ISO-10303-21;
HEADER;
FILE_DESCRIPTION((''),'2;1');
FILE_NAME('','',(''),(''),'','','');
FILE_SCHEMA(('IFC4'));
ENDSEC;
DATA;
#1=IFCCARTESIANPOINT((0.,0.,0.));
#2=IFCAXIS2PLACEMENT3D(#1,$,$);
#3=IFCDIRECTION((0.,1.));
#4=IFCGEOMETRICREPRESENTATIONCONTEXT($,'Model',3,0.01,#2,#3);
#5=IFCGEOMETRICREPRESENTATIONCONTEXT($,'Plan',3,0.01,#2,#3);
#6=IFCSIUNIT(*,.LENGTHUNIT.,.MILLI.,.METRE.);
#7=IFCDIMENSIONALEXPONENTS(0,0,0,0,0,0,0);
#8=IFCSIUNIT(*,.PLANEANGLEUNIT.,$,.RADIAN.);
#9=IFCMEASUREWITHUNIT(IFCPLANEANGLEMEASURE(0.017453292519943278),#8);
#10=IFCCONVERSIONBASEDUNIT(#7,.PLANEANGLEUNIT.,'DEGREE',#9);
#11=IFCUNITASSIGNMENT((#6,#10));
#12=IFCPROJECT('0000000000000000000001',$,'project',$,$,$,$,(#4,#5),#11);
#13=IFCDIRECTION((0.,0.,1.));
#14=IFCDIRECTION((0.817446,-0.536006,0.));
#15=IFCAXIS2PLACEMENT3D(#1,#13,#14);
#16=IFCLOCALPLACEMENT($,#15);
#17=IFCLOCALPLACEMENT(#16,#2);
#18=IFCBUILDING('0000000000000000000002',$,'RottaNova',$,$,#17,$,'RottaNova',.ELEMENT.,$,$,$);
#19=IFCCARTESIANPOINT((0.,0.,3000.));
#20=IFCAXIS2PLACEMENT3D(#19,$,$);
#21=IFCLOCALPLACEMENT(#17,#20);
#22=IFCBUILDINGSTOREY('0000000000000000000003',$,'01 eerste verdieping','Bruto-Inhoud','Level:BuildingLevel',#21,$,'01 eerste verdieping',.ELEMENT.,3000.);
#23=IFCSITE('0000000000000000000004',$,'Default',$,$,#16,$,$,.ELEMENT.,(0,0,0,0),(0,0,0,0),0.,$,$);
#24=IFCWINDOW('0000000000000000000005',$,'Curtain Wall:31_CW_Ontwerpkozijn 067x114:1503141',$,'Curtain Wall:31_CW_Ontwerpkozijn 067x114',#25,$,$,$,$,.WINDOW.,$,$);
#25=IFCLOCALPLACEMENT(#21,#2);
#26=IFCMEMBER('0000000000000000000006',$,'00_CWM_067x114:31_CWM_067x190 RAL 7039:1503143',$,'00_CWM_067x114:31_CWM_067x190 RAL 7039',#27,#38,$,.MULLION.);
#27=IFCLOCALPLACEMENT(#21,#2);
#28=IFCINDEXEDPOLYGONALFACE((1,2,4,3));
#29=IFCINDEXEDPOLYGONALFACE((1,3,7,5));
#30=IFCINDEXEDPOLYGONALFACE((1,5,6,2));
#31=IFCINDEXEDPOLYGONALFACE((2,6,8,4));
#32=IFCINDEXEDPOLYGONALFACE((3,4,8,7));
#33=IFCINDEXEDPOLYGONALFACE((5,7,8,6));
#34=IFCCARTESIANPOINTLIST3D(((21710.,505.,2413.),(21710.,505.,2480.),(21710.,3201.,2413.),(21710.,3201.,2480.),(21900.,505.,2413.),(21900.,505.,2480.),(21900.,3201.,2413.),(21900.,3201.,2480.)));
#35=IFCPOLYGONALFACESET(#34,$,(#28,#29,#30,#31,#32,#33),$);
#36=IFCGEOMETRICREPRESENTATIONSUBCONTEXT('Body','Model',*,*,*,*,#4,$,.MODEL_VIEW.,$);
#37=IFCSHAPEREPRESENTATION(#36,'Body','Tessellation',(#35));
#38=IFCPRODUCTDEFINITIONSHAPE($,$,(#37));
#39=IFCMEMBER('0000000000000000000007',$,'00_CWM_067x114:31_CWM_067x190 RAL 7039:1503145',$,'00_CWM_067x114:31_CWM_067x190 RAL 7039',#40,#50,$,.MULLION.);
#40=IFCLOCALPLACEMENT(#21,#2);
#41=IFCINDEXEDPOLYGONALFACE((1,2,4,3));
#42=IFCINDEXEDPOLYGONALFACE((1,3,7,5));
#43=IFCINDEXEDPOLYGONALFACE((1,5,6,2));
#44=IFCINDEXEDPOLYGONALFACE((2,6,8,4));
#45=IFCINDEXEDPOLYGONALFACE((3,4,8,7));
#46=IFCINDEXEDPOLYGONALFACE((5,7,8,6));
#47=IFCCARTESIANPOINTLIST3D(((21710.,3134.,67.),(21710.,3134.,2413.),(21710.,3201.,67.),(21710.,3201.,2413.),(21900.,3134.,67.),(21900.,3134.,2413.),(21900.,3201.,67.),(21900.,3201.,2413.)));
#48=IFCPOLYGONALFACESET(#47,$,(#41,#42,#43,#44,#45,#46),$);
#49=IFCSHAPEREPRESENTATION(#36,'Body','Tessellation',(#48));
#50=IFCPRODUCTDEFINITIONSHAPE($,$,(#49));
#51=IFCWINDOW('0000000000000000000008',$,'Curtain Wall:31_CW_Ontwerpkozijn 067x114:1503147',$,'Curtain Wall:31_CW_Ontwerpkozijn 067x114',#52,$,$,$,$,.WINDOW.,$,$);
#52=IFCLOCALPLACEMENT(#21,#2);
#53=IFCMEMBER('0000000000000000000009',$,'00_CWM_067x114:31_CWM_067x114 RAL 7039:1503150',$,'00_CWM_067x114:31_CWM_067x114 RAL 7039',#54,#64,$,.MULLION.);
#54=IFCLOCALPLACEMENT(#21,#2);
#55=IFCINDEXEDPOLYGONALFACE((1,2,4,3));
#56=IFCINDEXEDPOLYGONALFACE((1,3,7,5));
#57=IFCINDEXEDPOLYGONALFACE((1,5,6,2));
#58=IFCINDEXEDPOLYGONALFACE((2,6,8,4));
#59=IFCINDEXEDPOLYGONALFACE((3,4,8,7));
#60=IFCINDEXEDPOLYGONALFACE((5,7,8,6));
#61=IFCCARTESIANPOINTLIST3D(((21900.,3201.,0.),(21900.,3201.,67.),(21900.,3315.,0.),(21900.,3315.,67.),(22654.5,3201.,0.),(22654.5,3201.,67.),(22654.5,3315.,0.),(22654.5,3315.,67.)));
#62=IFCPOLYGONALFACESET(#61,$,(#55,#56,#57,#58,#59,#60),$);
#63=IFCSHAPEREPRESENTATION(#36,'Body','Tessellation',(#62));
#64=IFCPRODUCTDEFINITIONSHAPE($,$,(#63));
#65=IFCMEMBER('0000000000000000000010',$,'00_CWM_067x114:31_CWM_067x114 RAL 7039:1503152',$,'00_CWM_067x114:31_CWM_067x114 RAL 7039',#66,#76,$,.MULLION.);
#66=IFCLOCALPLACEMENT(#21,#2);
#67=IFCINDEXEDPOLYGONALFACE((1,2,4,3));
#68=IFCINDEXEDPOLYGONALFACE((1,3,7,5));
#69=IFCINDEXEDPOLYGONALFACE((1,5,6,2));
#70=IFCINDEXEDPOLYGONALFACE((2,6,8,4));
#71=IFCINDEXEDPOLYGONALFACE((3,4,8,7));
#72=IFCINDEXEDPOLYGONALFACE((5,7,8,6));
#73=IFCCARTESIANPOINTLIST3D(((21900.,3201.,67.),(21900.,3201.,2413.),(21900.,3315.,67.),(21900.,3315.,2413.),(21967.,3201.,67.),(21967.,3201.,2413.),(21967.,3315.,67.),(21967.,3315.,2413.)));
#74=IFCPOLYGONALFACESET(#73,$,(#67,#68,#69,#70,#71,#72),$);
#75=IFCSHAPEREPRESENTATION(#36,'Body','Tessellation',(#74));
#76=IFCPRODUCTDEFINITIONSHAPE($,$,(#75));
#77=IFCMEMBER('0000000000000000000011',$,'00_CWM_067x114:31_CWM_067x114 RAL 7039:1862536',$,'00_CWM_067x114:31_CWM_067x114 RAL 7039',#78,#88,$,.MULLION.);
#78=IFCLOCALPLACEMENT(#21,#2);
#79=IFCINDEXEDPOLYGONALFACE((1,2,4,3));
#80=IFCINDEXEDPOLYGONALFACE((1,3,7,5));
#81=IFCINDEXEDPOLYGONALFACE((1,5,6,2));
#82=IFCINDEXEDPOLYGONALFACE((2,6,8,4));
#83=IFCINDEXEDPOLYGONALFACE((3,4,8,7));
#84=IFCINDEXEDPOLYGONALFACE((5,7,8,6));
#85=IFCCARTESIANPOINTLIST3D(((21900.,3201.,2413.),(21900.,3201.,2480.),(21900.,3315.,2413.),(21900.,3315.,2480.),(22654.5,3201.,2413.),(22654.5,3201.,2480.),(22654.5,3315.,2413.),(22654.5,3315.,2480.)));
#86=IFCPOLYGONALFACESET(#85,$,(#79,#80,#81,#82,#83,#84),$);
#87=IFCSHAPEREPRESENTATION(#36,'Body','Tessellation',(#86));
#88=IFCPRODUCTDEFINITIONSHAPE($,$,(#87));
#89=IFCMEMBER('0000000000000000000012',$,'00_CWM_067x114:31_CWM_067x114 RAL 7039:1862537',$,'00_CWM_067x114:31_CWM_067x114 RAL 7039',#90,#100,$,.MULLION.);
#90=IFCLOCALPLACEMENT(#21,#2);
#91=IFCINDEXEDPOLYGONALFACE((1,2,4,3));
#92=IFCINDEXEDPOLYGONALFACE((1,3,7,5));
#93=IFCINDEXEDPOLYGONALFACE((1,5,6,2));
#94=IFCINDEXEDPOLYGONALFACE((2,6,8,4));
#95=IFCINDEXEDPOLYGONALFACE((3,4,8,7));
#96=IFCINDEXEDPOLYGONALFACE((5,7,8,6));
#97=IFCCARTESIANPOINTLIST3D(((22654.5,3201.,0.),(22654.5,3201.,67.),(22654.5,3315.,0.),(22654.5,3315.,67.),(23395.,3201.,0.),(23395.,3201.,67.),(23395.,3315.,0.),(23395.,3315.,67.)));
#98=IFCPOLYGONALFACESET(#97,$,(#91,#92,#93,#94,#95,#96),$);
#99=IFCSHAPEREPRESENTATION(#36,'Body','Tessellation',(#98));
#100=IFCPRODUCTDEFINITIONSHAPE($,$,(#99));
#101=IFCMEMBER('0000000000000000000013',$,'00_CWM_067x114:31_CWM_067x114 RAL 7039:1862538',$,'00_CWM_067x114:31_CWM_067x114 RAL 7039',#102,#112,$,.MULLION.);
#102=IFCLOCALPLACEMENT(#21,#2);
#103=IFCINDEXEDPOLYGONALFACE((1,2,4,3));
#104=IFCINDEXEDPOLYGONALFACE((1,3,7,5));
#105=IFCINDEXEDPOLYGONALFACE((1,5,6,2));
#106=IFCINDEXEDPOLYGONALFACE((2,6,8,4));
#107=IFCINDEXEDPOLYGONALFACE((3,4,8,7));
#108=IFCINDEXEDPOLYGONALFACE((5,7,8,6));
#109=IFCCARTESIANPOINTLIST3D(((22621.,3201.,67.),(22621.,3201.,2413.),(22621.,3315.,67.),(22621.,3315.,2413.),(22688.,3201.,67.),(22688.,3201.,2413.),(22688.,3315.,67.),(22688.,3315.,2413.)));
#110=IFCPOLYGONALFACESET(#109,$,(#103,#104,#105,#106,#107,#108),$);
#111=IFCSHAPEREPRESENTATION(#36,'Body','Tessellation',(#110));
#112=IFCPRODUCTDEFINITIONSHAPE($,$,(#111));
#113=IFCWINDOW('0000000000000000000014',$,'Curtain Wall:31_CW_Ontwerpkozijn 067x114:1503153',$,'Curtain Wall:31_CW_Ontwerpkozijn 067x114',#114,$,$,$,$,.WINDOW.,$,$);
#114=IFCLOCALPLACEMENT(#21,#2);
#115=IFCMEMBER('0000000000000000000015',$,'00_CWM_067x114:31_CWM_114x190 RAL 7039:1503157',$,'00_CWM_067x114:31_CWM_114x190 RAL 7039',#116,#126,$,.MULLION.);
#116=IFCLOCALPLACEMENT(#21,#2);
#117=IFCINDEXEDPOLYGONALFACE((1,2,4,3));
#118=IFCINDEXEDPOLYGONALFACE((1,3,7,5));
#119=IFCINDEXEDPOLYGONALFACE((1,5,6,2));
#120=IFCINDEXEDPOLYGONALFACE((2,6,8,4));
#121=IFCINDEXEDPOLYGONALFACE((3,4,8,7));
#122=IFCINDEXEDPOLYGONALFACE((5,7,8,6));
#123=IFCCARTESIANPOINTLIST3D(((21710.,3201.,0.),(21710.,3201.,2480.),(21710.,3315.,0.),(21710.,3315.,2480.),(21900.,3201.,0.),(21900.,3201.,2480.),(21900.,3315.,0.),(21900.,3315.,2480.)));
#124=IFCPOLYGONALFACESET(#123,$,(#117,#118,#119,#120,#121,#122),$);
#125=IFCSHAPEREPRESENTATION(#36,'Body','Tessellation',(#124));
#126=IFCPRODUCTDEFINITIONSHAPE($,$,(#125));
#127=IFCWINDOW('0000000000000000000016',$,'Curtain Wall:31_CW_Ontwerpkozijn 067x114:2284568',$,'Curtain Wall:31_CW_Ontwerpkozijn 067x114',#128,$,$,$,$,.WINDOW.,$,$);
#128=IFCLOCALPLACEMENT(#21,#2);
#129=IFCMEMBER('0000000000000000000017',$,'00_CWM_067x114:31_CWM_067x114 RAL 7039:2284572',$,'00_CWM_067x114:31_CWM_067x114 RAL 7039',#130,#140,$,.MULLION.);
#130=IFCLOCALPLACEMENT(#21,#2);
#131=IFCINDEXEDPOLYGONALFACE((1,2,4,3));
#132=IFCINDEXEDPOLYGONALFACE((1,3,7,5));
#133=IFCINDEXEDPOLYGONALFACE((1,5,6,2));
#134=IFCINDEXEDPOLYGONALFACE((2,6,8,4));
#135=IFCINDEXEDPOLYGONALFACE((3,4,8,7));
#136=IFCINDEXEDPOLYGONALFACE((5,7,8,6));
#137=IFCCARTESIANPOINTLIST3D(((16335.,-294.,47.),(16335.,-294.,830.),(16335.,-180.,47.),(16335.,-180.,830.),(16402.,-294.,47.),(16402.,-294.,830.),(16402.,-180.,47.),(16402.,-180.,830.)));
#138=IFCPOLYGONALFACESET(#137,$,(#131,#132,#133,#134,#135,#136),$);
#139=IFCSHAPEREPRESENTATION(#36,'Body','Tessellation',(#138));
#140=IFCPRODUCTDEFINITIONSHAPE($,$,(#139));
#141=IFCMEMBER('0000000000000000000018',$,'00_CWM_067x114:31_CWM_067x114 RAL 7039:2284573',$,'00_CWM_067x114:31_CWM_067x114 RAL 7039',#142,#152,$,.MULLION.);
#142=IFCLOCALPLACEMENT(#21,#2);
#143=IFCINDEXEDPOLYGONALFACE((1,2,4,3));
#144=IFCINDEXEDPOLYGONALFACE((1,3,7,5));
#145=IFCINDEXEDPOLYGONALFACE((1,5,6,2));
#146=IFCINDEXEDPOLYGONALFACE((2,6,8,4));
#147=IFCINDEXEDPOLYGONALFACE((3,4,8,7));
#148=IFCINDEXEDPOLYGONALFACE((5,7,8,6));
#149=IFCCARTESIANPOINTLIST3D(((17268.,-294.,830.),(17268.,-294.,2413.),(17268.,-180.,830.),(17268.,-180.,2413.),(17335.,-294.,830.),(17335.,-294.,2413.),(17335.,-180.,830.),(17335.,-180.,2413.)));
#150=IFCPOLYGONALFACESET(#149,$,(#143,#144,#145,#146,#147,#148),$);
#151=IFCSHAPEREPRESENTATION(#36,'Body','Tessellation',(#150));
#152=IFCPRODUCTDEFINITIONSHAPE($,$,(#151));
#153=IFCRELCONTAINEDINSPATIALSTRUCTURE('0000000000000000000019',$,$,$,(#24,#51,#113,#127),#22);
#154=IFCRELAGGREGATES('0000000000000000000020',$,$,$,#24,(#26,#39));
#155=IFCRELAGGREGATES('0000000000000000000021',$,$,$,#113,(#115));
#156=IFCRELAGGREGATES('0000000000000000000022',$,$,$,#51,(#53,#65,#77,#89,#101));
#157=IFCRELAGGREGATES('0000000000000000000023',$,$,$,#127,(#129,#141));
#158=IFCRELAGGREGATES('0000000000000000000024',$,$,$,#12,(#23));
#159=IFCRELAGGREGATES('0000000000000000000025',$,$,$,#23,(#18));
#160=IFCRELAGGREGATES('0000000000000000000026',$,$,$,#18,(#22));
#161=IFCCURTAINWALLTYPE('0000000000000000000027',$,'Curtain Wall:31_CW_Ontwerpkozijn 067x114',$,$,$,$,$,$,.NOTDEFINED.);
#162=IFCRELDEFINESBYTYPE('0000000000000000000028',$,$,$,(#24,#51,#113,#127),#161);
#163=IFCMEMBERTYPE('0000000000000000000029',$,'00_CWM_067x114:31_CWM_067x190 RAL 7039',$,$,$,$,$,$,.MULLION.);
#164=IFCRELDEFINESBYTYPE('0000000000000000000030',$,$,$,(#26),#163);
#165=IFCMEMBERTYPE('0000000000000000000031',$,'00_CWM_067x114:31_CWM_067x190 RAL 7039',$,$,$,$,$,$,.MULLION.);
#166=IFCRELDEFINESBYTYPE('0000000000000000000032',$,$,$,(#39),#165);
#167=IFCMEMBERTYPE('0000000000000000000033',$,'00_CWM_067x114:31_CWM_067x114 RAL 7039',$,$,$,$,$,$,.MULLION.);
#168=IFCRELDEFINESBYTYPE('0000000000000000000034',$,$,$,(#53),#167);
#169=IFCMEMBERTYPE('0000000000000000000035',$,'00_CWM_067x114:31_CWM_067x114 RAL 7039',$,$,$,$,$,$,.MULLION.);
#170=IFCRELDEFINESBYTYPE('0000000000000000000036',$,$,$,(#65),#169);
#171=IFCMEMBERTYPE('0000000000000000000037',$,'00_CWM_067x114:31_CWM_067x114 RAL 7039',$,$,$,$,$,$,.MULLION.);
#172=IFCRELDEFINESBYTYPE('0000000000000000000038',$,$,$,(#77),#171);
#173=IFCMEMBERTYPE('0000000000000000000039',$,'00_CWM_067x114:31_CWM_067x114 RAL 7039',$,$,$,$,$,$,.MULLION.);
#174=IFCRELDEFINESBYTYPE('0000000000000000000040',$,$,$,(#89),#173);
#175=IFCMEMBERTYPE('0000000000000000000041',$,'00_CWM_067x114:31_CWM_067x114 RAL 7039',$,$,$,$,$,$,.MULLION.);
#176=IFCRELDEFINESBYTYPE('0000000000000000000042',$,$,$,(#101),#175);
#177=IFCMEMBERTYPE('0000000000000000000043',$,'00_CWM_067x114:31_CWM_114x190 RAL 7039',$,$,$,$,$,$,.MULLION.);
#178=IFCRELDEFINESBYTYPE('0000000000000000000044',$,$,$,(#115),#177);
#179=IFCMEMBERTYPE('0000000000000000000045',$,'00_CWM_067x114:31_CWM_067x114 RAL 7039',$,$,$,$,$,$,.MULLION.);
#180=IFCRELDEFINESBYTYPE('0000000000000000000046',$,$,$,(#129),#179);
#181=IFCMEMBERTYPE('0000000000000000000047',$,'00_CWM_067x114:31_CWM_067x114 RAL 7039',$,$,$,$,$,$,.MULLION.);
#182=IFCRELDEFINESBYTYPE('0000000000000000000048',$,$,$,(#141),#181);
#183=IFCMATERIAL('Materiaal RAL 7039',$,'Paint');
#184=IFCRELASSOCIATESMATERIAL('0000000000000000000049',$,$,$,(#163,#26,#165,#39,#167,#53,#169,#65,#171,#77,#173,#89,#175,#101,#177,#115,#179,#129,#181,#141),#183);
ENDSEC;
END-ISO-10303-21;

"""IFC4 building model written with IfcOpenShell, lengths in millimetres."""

from ifc_helpers import new_model, entity, si_unit, converted_unit, direction, frame, origin, place, context, subcontext, project, spatial, indexed_curve, outline, extrude, source, transform, mapped, material, type_object, type_shapes, element, aggregate, save


model = new_model("IFC4")

# Units and contexts
model_context = context("Model", 3, precision=0.01, world=origin(), true_north=direction((0.0, 1.0)))
plan_context = context("Plan", 3, precision=0.01, world=origin(), true_north=direction((0.0, 1.0)))
body_context = subcontext(model_context, "Body", "Model", "MODEL_VIEW")
ifc_project = project(units=[si_unit("LENGTHUNIT", "METRE", prefix="MILLI"), converted_unit("PLANEANGLEUNIT", "DEGREE", entity("IfcPlaneAngleMeasure", 0.017453292519943278), si_unit("PLANEANGLEUNIT", "RADIAN"), dimensions=[0, 0, 0, 0, 0, 0, 0])], contexts=[model_context, plan_context])

# Site, building, storey
site_placement = place(None, frame((0.0, 0.0, 0.0), z_axis=(0.0, 0.0, 1.0), x_axis=(0.817446, -0.536006, 0.0)))
site = spatial("IfcSite", under=ifc_project, at=site_placement, Name="Default", CompositionType="ELEMENT", RefLatitude=(0, 0, 0, 0), RefLongitude=(0, 0, 0, 0), RefElevation=0.0)
building_placement = place(site_placement, origin())
building = spatial("IfcBuilding", under=site, at=building_placement, Name="RottaNova", LongName="RottaNova", CompositionType="ELEMENT")
storey_placement = place(building_placement, frame((0.0, 0.0, 3000.0)))
storey = spatial("IfcBuildingStorey", under=building, at=storey_placement, Name="01 eerste verdieping", Description="Bruto-Inhoud", ObjectType="Level:BuildingLevel", LongName="01 eerste verdieping", CompositionType="ELEMENT", Elevation=3000.0)

# Windows, members
curtain_wall_type = type_object("IfcCurtainWallType", Name="Curtain Wall:31_CW_Ontwerpkozijn 067x114", PredefinedType="NOTDEFINED")
window_1_placement = place(storey_placement, frame((0.0, 0.0, -3000.0)))
window_1 = element("IfcWindow", 1, at=window_1_placement, inside=storey, type_object=curtain_wall_type, Name="Curtain Wall:31_CW_Ontwerpkozijn 067x114:1503141", ObjectType="Curtain Wall:31_CW_Ontwerpkozijn 067x114", PredefinedType="WINDOW")
ifc_material_1 = material(Name="Materiaal RAL 7039", Category="Paint")
member_type_1 = type_object("IfcMemberType", Name="00_CWM_067x114:31_CWM_067x190 RAL 7039", PredefinedType="MULLION", material=ifc_material_1)
shared_shape_1 = source(origin(), body_context, "Body", "SweptSolid", [
    extrude(outline(indexed_curve([(-33.5, -95.0), (33.5, -95.0), (33.5, 95.0), (-33.5, 95.0), (-33.5, -95.0)], self_intersect=False)), frame((-33.5, 95.0, -2696.0), z_axis=(0.0, 0.0, 1.0), x_axis=(-1.0, 0.0, 0.0)), (0.0, 0.0, 1.0), 2696.0),
])
type_shapes(member_type_1, [shared_shape_1])
member_1_placement = place(window_1_placement, frame((21710.0, 3201.0, 5480.0), z_axis=(0.0, 1.0, 0.0), x_axis=(0.0, 0.0, 1.0)))
member_1 = element("IfcMember", 2, at=member_1_placement, type_object=member_type_1, material=ifc_material_1, Name="00_CWM_067x114:31_CWM_067x190 RAL 7039:1503143", ObjectType="00_CWM_067x114:31_CWM_067x190 RAL 7039", PredefinedType="MULLION", context=body_context, shape_type="MappedRepresentation", body=[
    mapped(shared_shape_1, transform((0.0, 0.0, 0.0), scale=1.0)),
])
member_type_2 = type_object("IfcMemberType", Name="00_CWM_067x114:31_CWM_067x190 RAL 7039", PredefinedType="MULLION", material=ifc_material_1)
shared_shape_2 = source(origin(), body_context, "Body", "SweptSolid", [
    extrude(outline(indexed_curve([(-33.5, -95.0), (33.5, -95.0), (33.5, 95.0), (-33.5, 95.0), (-33.5, -95.0)], self_intersect=False)), frame((-33.5, 95.0, -2346.0), z_axis=(0.0, 0.0, 1.0), x_axis=(-1.0, 0.0, 0.0)), (0.0, 0.0, 1.0), 2346.0),
])
type_shapes(member_type_2, [shared_shape_2])
member_2_placement = place(window_1_placement, frame((21710.0, 3201.0, 3067.0), z_axis=(0.0, 0.0, -1.0), x_axis=(0.0, 1.0, 0.0)))
member_2 = element("IfcMember", 3, at=member_2_placement, type_object=member_type_2, material=ifc_material_1, Name="00_CWM_067x114:31_CWM_067x190 RAL 7039:1503145", ObjectType="00_CWM_067x114:31_CWM_067x190 RAL 7039", PredefinedType="MULLION", context=body_context, shape_type="MappedRepresentation", body=[
    mapped(shared_shape_2, transform((0.0, 0.0, 0.0), scale=1.0)),
])
aggregate(window_1, [member_1, member_2])
window_2_placement = place(storey_placement, frame((0.0, 0.0, -3000.0)))
window_2 = element("IfcWindow", 4, at=window_2_placement, inside=storey, type_object=curtain_wall_type, Name="Curtain Wall:31_CW_Ontwerpkozijn 067x114:1503147", ObjectType="Curtain Wall:31_CW_Ontwerpkozijn 067x114", PredefinedType="WINDOW")
member_type_3 = type_object("IfcMemberType", Name="00_CWM_067x114:31_CWM_067x114 RAL 7039", PredefinedType="MULLION", material=ifc_material_1)
shared_shape_3 = source(origin(), body_context, "Body", "SweptSolid", [
    extrude(outline(indexed_curve([(-33.5, -57.0), (33.5, -57.0), (33.5, 57.0), (-33.5, 57.0), (-33.5, -57.0)], self_intersect=False)), frame((-33.5, 57.0, -754.5), z_axis=(0.0, 0.0, 1.0), x_axis=(-1.0, 0.0, 0.0)), (0.0, 0.0, 1.0), 754.5),
])
type_shapes(member_type_3, [shared_shape_3])
member_3_placement = place(window_2_placement, frame((21900.0, 3315.0, 3000.0), z_axis=(-1.0, 0.0, 0.0), x_axis=(0.0, 0.0, -1.0)))
member_3 = element("IfcMember", 5, at=member_3_placement, type_object=member_type_3, material=ifc_material_1, Name="00_CWM_067x114:31_CWM_067x114 RAL 7039:1503150", ObjectType="00_CWM_067x114:31_CWM_067x114 RAL 7039", PredefinedType="MULLION", context=body_context, shape_type="MappedRepresentation", body=[
    mapped(shared_shape_3, transform((0.0, 0.0, 0.0), scale=1.0)),
])
member_type_4 = type_object("IfcMemberType", Name="00_CWM_067x114:31_CWM_067x114 RAL 7039", PredefinedType="MULLION", material=ifc_material_1)
shared_shape_4 = source(origin(), body_context, "Body", "SweptSolid", [
    extrude(outline(indexed_curve([(-33.5, -57.0), (33.5, -57.0), (33.5, 57.0), (-33.5, 57.0), (-33.5, -57.0)], self_intersect=False)), frame((-33.5, 57.0, -2346.0), z_axis=(0.0, 0.0, 1.0), x_axis=(-1.0, 0.0, 0.0)), (0.0, 0.0, 1.0), 2346.0),
])
type_shapes(member_type_4, [shared_shape_4])
member_4_placement = place(window_2_placement, frame((21900.0, 3315.0, 5413.0), z_axis=(0.0, 0.0, 1.0), x_axis=(-1.0, 0.0, 0.0)))
member_4 = element("IfcMember", 6, at=member_4_placement, type_object=member_type_4, material=ifc_material_1, Name="00_CWM_067x114:31_CWM_067x114 RAL 7039:1503152", ObjectType="00_CWM_067x114:31_CWM_067x114 RAL 7039", PredefinedType="MULLION", context=body_context, shape_type="MappedRepresentation", body=[
    mapped(shared_shape_4, transform((0.0, 0.0, 0.0), scale=1.0)),
])
member_type_5 = type_object("IfcMemberType", Name="00_CWM_067x114:31_CWM_067x114 RAL 7039", PredefinedType="MULLION", material=ifc_material_1)
shared_shape_5 = source(origin(), body_context, "Body", "SweptSolid", [
    extrude(outline(indexed_curve([(-33.5, -57.0), (33.5, -57.0), (33.5, 57.0), (-33.5, 57.0), (-33.5, -57.0)], self_intersect=False)), frame((-33.5, 57.0, -754.5), z_axis=(0.0, 0.0, 1.0), x_axis=(-1.0, 0.0, 0.0)), (0.0, 0.0, 1.0), 754.5),
])
type_shapes(member_type_5, [shared_shape_5])
member_5_placement = place(window_2_placement, frame((22654.5, 3315.0, 5480.0), z_axis=(1.0, 0.0, 0.0), x_axis=(0.0, 0.0, 1.0)))
member_5 = element("IfcMember", 7, at=member_5_placement, type_object=member_type_5, material=ifc_material_1, Name="00_CWM_067x114:31_CWM_067x114 RAL 7039:1862536", ObjectType="00_CWM_067x114:31_CWM_067x114 RAL 7039", PredefinedType="MULLION", context=body_context, shape_type="MappedRepresentation", body=[
    mapped(shared_shape_5, transform((0.0, 0.0, 0.0), scale=1.0)),
])
member_type_6 = type_object("IfcMemberType", Name="00_CWM_067x114:31_CWM_067x114 RAL 7039", PredefinedType="MULLION", material=ifc_material_1)
shared_shape_6 = source(origin(), body_context, "Body", "SweptSolid", [
    extrude(outline(indexed_curve([(-33.5, -57.0), (33.5, -57.0), (33.5, 57.0), (-33.5, 57.0), (-33.5, -57.0)], self_intersect=False)), frame((-33.5, 57.0, -740.5), z_axis=(0.0, 0.0, 1.0), x_axis=(-1.0, 0.0, 0.0)), (0.0, 0.0, 1.0), 740.5),
])
type_shapes(member_type_6, [shared_shape_6])
member_6_placement = place(window_2_placement, frame((22654.5, 3315.0, 3000.0), z_axis=(-1.0, 0.0, 0.0), x_axis=(0.0, 0.0, -1.0)))
member_6 = element("IfcMember", 8, at=member_6_placement, type_object=member_type_6, material=ifc_material_1, Name="00_CWM_067x114:31_CWM_067x114 RAL 7039:1862537", ObjectType="00_CWM_067x114:31_CWM_067x114 RAL 7039", PredefinedType="MULLION", context=body_context, shape_type="MappedRepresentation", body=[
    mapped(shared_shape_6, transform((0.0, 0.0, 0.0), scale=1.0)),
])
member_type_7 = type_object("IfcMemberType", Name="00_CWM_067x114:31_CWM_067x114 RAL 7039", PredefinedType="MULLION", material=ifc_material_1)
shared_shape_7 = source(origin(), body_context, "Body", "SweptSolid", [
    extrude(outline(indexed_curve([(-33.5, -57.0), (33.5, -57.0), (33.5, 57.0), (-33.5, 57.0), (-33.5, -57.0)], self_intersect=False)), frame((0.0, 57.0, -2346.0), z_axis=(0.0, 0.0, 1.0), x_axis=(-1.0, 0.0, 0.0)), (0.0, 0.0, 1.0), 2346.0),
])
type_shapes(member_type_7, [shared_shape_7])
member_7_placement = place(window_2_placement, frame((22654.5, 3315.0, 3067.0), z_axis=(0.0, 0.0, -1.0), x_axis=(1.0, 0.0, 0.0)))
member_7 = element("IfcMember", 9, at=member_7_placement, type_object=member_type_7, material=ifc_material_1, Name="00_CWM_067x114:31_CWM_067x114 RAL 7039:1862538", ObjectType="00_CWM_067x114:31_CWM_067x114 RAL 7039", PredefinedType="MULLION", context=body_context, shape_type="MappedRepresentation", body=[
    mapped(shared_shape_7, transform((0.0, 0.0, 0.0), scale=1.0)),
])

# Window, member
window_3_placement = place(storey_placement, frame((0.0, 0.0, -3000.0)))
window_3 = element("IfcWindow", 10, at=window_3_placement, inside=storey, type_object=curtain_wall_type, Name="Curtain Wall:31_CW_Ontwerpkozijn 067x114:1503153", ObjectType="Curtain Wall:31_CW_Ontwerpkozijn 067x114", PredefinedType="WINDOW")
member_type_8 = type_object("IfcMemberType", Name="00_CWM_067x114:31_CWM_114x190 RAL 7039", PredefinedType="MULLION", material=ifc_material_1)
shared_shape_8 = source(origin(), body_context, "Body", "SweptSolid", [
    extrude(outline(indexed_curve([(-57.0, -95.0), (57.0, -95.0), (57.0, 95.0), (-57.0, 95.0), (-57.0, -95.0)], self_intersect=False)), frame((-95.0, 0.0, -2480.0), z_axis=(0.0, 0.0, 1.0), x_axis=(0.0, -1.0, 0.0)), (0.0, 0.0, 1.0), 2480.0),
])
type_shapes(member_type_8, [shared_shape_8])
member_8_placement = place(window_3_placement, frame((21710.0, 3258.0, 5480.0), z_axis=(0.0, 0.0, 1.0), x_axis=(-1.0, 0.0, 0.0)))
member_8 = element("IfcMember", 11, at=member_8_placement, type_object=member_type_8, material=ifc_material_1, Name="00_CWM_067x114:31_CWM_114x190 RAL 7039:1503157", ObjectType="00_CWM_067x114:31_CWM_114x190 RAL 7039", PredefinedType="MULLION", context=body_context, shape_type="MappedRepresentation", body=[
    mapped(shared_shape_8, transform((0.0, 0.0, 0.0), scale=1.0)),
])
aggregate(window_3, [member_8])

# Window, members
window_4_placement = place(storey_placement, frame((0.0, 0.0, -3000.0)))
window_4 = element("IfcWindow", 12, at=window_4_placement, inside=storey, type_object=curtain_wall_type, Name="Curtain Wall:31_CW_Ontwerpkozijn 067x114:2284568", ObjectType="Curtain Wall:31_CW_Ontwerpkozijn 067x114", PredefinedType="WINDOW")
member_type_9 = type_object("IfcMemberType", Name="00_CWM_067x114:31_CWM_067x114 RAL 7039", PredefinedType="MULLION", material=ifc_material_1)
shared_shape_9 = source(origin(), body_context, "Body", "SweptSolid", [
    extrude(outline(indexed_curve([(-33.5, -57.0), (33.5, -57.0), (33.5, 57.0), (-33.5, 57.0), (-33.5, -57.0)], self_intersect=False)), frame((-33.5, -57.0, -783.0), z_axis=(0.0, 0.0, 1.0), x_axis=(-1.0, 0.0, 0.0)), (0.0, 0.0, 1.0), 783.0),
])
type_shapes(member_type_9, [shared_shape_9])
member_9_placement = place(window_4_placement, frame((16335.0, -180.0, 3047.0), z_axis=(0.0, 0.0, -1.0), x_axis=(-1.0, 0.0, 0.0)))
member_9 = element("IfcMember", 13, at=member_9_placement, type_object=member_type_9, material=ifc_material_1, Name="00_CWM_067x114:31_CWM_067x114 RAL 7039:2284572", ObjectType="00_CWM_067x114:31_CWM_067x114 RAL 7039", PredefinedType="MULLION", context=body_context, shape_type="MappedRepresentation", body=[
    mapped(shared_shape_9, transform((0.0, 0.0, 0.0), scale=1.0)),
])
member_type_10 = type_object("IfcMemberType", Name="00_CWM_067x114:31_CWM_067x114 RAL 7039", PredefinedType="MULLION", material=ifc_material_1)
shared_shape_10 = source(origin(), body_context, "Body", "SweptSolid", [
    extrude(outline(indexed_curve([(-33.5, -57.0), (33.5, -57.0), (33.5, 57.0), (-33.5, 57.0), (-33.5, -57.0)], self_intersect=False)), frame((-33.5, -57.0, -1583.0), z_axis=(0.0, 0.0, 1.0), x_axis=(-1.0, 0.0, 0.0)), (0.0, 0.0, 1.0), 1583.0),
])
type_shapes(member_type_10, [shared_shape_10])
member_10_placement = place(window_4_placement, frame((17335.0, -180.0, 5413.0)))
member_10 = element("IfcMember", 14, at=member_10_placement, type_object=member_type_10, material=ifc_material_1, Name="00_CWM_067x114:31_CWM_067x114 RAL 7039:2284573", ObjectType="00_CWM_067x114:31_CWM_067x114 RAL 7039", PredefinedType="MULLION", context=body_context, shape_type="MappedRepresentation", body=[
    mapped(shared_shape_10, transform((0.0, 0.0, 0.0), scale=1.0)),
])

aggregate(window_2, [member_3, member_4, member_5, member_6, member_7])
aggregate(window_4, [member_9, member_10])

save(model, "model.ifc")
